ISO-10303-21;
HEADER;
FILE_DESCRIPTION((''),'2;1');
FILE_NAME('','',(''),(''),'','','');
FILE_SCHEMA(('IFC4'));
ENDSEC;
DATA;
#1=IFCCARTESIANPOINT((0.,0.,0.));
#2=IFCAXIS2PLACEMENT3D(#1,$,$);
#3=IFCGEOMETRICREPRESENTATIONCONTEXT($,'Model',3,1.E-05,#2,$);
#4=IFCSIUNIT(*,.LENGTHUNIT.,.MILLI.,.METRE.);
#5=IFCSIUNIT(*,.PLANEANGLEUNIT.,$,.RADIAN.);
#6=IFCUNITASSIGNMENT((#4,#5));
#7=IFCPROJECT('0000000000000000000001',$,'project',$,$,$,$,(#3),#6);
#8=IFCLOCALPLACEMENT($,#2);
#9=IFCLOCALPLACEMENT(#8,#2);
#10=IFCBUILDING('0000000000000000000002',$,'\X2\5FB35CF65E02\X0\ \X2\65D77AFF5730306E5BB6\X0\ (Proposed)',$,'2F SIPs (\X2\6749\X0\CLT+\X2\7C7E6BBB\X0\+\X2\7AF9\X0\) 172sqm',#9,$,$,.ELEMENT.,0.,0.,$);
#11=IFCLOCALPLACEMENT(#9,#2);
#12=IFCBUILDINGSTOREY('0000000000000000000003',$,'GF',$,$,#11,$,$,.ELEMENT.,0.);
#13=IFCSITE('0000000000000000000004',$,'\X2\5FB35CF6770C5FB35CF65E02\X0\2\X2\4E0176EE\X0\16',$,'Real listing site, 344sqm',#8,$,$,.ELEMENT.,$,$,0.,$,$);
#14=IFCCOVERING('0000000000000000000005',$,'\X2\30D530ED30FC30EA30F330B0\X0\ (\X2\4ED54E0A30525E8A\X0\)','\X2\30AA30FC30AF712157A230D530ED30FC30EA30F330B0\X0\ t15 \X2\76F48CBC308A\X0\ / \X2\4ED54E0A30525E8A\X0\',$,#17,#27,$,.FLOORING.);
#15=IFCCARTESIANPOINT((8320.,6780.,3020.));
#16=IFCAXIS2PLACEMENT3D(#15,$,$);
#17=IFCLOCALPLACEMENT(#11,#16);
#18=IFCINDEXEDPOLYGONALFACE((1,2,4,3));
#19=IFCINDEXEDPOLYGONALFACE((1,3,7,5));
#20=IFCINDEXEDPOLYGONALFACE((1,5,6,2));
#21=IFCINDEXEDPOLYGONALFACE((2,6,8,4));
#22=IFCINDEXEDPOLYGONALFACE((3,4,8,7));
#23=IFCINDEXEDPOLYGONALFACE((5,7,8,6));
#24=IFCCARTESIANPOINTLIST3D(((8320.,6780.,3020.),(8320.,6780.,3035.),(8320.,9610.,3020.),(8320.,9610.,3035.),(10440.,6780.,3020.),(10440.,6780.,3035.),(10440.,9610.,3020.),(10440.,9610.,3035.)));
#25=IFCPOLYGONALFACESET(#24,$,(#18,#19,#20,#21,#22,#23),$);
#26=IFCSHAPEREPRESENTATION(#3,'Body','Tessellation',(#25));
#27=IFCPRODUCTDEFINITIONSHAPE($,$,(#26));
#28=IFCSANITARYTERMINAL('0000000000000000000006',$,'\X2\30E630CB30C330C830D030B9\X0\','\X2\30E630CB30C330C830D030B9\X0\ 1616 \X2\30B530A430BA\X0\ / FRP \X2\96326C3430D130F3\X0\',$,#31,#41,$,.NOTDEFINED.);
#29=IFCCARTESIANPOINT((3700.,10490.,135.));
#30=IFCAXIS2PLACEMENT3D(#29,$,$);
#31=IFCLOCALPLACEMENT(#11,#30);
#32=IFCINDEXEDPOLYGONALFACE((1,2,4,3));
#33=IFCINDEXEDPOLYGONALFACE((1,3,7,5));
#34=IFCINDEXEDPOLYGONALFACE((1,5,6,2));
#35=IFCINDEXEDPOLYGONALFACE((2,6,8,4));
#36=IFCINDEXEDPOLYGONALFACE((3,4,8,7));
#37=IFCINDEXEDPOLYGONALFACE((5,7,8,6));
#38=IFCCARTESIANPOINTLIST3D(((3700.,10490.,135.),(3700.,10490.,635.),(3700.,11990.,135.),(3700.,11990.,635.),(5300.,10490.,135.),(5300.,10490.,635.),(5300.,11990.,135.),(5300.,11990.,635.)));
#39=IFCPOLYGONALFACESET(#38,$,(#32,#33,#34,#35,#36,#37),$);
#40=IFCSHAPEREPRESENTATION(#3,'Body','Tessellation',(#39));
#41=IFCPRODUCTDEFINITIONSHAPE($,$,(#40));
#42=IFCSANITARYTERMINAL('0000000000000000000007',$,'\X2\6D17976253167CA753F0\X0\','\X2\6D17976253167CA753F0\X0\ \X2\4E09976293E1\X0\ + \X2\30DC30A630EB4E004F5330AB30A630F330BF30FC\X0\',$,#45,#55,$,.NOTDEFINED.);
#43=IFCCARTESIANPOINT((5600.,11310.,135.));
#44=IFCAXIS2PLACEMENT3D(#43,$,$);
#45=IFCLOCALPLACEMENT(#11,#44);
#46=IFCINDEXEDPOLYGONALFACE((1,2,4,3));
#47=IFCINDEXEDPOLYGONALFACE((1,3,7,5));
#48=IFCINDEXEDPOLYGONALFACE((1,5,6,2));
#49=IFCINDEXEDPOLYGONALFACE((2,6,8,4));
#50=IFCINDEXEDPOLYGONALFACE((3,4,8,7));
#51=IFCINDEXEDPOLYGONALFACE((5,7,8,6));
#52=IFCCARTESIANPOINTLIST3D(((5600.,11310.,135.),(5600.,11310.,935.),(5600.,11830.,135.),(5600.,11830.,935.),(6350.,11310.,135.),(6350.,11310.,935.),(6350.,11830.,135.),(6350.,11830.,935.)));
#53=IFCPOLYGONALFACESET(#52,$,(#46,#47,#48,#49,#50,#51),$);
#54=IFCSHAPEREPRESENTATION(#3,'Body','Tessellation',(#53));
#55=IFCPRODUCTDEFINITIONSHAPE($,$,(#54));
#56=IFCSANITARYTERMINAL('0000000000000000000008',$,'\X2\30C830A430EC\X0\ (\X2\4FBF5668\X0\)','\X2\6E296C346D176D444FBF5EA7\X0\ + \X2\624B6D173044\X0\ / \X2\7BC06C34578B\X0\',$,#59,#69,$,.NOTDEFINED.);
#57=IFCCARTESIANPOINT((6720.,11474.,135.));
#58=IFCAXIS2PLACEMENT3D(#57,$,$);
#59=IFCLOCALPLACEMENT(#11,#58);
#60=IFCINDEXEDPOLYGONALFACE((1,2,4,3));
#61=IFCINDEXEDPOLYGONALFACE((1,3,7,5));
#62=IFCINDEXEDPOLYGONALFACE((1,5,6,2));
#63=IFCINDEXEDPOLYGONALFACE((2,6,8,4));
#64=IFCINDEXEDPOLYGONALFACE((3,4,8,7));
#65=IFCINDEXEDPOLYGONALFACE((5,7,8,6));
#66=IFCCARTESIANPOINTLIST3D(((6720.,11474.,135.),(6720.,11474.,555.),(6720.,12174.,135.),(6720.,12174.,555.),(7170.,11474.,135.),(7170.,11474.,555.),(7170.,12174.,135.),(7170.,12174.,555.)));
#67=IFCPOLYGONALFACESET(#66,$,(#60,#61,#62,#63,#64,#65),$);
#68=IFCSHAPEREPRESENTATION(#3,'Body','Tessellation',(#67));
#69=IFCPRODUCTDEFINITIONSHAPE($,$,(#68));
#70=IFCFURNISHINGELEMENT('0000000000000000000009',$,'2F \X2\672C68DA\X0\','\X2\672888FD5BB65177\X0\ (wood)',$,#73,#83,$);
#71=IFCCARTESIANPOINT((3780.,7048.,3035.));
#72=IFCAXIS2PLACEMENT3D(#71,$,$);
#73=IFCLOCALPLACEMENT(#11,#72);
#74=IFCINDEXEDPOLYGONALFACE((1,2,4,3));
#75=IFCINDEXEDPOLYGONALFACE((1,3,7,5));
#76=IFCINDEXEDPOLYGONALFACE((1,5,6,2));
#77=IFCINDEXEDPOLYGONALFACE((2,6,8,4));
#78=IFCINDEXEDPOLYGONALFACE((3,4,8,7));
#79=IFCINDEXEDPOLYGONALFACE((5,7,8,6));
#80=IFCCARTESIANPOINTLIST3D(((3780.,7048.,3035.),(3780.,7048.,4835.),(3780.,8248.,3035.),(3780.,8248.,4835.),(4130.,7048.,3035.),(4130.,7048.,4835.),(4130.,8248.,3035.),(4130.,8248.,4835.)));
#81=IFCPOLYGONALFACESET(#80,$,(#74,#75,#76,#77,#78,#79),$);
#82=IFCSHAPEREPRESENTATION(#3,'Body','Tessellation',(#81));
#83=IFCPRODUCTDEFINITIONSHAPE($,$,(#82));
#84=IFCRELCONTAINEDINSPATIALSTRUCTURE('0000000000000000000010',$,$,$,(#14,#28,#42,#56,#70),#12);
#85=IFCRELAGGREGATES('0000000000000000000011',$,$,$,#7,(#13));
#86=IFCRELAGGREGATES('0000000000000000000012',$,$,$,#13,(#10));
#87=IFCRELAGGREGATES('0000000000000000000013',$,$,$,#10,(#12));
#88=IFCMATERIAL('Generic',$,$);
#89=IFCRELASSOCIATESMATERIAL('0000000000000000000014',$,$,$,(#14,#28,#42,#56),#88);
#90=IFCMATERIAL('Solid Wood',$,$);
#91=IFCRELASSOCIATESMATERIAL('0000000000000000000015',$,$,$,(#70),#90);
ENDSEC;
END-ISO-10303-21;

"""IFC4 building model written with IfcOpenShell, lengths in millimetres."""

from ifc_helpers import new_model, si_unit, frame, frame_2d, origin, place, context, project, spatial, rectangle, extrude, material, element, save


model = new_model("IFC4")

# Units and contexts
model_context = context("Model", 3, precision=1e-05, world=origin())
ifc_project = project(units=[si_unit("LENGTHUNIT", "METRE", prefix="MILLI"), si_unit("PLANEANGLEUNIT", "RADIAN")], contexts=[model_context])

# Site, building, storey
site_placement = place(None, origin())
site = spatial("IfcSite", under=ifc_project, at=site_placement, Name="徳島県徳島市2丁目16", ObjectType="Real listing site, 344sqm", CompositionType="ELEMENT", RefElevation=0.0)
building_placement = place(site_placement, origin())
building = spatial("IfcBuilding", under=site, at=building_placement, Name="徳島市 旗竿地の家 (Proposed)", ObjectType="2F SIPs (杉CLT+籾殻+竹) 172sqm", CompositionType="ELEMENT", ElevationOfRefHeight=0.0, ElevationOfTerrain=0.0)
storey_placement = place(building_placement, origin())
storey = spatial("IfcBuildingStorey", under=building, at=storey_placement, Name="GF", CompositionType="ELEMENT", Elevation=0.0)

# Shared definitions
ifc_material_1 = material(Name="Solid Wood")
ifc_material_2 = material(Name="Generic")

# Covering
covering_1_placement = place(storey_placement, frame((8320.0, 6780.0, 3020.0)))
element("IfcCovering", 1, at=covering_1_placement, inside=storey, material=ifc_material_2, Name="フローリング (仕上げ床)", Description="オーク無垢フローリング t15 直貼り / 仕上げ床", PredefinedType="FLOORING", context=model_context, shape_type="SweptSolid", body=[
    extrude(rectangle(XDim=2120.0, YDim=2830.0, at=frame_2d((1060.0, 1415.0))), frame((8320.0, 6780.0, 3020.0)), (0.0, 0.0, 1.0), 15.0),
])

# Sanitary terminals
sanitary_terminal_1_placement = place(storey_placement, frame((3700.0, 10490.0, 135.0)))
element("IfcSanitaryTerminal", 2, at=sanitary_terminal_1_placement, inside=storey, material=ifc_material_2, Name="ユニットバス", Description="ユニットバス 1616 サイズ / FRP 防水パン", PredefinedType="NOTDEFINED", context=model_context, shape_type="SweptSolid", body=[
    extrude(rectangle(XDim=1600.0, YDim=1500.0, at=frame_2d((800.0, 750.0))), frame((3700.0, 10490.0, 135.0)), (0.0, 0.0, 1.0), 500.0),
])
sanitary_terminal_2_placement = place(storey_placement, frame((5600.0, 11310.0, 135.0)))
element("IfcSanitaryTerminal", 3, at=sanitary_terminal_2_placement, inside=storey, material=ifc_material_2, Name="洗面化粧台", Description="洗面化粧台 三面鏡 + ボウル一体カウンター", PredefinedType="NOTDEFINED", context=model_context, shape_type="SweptSolid", body=[
    extrude(rectangle(XDim=750.0, YDim=520.0, at=frame_2d((375.0, 260.0))), frame((5600.0, 11310.0, 135.0)), (0.0, 0.0, 1.0), 800.0),
])
sanitary_terminal_3_placement = place(storey_placement, frame((6720.0, 11474.0, 135.0)))
element("IfcSanitaryTerminal", 4, at=sanitary_terminal_3_placement, inside=storey, material=ifc_material_2, Name="トイレ (便器)", Description="温水洗浄便座 + 手洗い / 節水型", PredefinedType="NOTDEFINED", context=model_context, shape_type="SweptSolid", body=[
    extrude(rectangle(XDim=450.0, YDim=700.0, at=frame_2d((225.0, 350.0))), frame((6720.0, 11474.0, 135.0)), (0.0, 0.0, 1.0), 420.0),
])

# Furnishing element
furnishing_placement = place(storey_placement, frame((3780.0, 7048.0, 3035.0)))
element("IfcFurnishingElement", 5, at=furnishing_placement, inside=storey, material=ifc_material_1, Name="2F 本棚", Description="木製家具 (wood)", context=model_context, shape_type="SweptSolid", body=[
    extrude(rectangle(XDim=350.0, YDim=1200.0, at=frame_2d((175.0, 600.0))), frame((3780.0, 7048.0, 3035.0)), (0.0, 0.0, 1.0), 1800.0),
])

save(model, "model.ifc")
